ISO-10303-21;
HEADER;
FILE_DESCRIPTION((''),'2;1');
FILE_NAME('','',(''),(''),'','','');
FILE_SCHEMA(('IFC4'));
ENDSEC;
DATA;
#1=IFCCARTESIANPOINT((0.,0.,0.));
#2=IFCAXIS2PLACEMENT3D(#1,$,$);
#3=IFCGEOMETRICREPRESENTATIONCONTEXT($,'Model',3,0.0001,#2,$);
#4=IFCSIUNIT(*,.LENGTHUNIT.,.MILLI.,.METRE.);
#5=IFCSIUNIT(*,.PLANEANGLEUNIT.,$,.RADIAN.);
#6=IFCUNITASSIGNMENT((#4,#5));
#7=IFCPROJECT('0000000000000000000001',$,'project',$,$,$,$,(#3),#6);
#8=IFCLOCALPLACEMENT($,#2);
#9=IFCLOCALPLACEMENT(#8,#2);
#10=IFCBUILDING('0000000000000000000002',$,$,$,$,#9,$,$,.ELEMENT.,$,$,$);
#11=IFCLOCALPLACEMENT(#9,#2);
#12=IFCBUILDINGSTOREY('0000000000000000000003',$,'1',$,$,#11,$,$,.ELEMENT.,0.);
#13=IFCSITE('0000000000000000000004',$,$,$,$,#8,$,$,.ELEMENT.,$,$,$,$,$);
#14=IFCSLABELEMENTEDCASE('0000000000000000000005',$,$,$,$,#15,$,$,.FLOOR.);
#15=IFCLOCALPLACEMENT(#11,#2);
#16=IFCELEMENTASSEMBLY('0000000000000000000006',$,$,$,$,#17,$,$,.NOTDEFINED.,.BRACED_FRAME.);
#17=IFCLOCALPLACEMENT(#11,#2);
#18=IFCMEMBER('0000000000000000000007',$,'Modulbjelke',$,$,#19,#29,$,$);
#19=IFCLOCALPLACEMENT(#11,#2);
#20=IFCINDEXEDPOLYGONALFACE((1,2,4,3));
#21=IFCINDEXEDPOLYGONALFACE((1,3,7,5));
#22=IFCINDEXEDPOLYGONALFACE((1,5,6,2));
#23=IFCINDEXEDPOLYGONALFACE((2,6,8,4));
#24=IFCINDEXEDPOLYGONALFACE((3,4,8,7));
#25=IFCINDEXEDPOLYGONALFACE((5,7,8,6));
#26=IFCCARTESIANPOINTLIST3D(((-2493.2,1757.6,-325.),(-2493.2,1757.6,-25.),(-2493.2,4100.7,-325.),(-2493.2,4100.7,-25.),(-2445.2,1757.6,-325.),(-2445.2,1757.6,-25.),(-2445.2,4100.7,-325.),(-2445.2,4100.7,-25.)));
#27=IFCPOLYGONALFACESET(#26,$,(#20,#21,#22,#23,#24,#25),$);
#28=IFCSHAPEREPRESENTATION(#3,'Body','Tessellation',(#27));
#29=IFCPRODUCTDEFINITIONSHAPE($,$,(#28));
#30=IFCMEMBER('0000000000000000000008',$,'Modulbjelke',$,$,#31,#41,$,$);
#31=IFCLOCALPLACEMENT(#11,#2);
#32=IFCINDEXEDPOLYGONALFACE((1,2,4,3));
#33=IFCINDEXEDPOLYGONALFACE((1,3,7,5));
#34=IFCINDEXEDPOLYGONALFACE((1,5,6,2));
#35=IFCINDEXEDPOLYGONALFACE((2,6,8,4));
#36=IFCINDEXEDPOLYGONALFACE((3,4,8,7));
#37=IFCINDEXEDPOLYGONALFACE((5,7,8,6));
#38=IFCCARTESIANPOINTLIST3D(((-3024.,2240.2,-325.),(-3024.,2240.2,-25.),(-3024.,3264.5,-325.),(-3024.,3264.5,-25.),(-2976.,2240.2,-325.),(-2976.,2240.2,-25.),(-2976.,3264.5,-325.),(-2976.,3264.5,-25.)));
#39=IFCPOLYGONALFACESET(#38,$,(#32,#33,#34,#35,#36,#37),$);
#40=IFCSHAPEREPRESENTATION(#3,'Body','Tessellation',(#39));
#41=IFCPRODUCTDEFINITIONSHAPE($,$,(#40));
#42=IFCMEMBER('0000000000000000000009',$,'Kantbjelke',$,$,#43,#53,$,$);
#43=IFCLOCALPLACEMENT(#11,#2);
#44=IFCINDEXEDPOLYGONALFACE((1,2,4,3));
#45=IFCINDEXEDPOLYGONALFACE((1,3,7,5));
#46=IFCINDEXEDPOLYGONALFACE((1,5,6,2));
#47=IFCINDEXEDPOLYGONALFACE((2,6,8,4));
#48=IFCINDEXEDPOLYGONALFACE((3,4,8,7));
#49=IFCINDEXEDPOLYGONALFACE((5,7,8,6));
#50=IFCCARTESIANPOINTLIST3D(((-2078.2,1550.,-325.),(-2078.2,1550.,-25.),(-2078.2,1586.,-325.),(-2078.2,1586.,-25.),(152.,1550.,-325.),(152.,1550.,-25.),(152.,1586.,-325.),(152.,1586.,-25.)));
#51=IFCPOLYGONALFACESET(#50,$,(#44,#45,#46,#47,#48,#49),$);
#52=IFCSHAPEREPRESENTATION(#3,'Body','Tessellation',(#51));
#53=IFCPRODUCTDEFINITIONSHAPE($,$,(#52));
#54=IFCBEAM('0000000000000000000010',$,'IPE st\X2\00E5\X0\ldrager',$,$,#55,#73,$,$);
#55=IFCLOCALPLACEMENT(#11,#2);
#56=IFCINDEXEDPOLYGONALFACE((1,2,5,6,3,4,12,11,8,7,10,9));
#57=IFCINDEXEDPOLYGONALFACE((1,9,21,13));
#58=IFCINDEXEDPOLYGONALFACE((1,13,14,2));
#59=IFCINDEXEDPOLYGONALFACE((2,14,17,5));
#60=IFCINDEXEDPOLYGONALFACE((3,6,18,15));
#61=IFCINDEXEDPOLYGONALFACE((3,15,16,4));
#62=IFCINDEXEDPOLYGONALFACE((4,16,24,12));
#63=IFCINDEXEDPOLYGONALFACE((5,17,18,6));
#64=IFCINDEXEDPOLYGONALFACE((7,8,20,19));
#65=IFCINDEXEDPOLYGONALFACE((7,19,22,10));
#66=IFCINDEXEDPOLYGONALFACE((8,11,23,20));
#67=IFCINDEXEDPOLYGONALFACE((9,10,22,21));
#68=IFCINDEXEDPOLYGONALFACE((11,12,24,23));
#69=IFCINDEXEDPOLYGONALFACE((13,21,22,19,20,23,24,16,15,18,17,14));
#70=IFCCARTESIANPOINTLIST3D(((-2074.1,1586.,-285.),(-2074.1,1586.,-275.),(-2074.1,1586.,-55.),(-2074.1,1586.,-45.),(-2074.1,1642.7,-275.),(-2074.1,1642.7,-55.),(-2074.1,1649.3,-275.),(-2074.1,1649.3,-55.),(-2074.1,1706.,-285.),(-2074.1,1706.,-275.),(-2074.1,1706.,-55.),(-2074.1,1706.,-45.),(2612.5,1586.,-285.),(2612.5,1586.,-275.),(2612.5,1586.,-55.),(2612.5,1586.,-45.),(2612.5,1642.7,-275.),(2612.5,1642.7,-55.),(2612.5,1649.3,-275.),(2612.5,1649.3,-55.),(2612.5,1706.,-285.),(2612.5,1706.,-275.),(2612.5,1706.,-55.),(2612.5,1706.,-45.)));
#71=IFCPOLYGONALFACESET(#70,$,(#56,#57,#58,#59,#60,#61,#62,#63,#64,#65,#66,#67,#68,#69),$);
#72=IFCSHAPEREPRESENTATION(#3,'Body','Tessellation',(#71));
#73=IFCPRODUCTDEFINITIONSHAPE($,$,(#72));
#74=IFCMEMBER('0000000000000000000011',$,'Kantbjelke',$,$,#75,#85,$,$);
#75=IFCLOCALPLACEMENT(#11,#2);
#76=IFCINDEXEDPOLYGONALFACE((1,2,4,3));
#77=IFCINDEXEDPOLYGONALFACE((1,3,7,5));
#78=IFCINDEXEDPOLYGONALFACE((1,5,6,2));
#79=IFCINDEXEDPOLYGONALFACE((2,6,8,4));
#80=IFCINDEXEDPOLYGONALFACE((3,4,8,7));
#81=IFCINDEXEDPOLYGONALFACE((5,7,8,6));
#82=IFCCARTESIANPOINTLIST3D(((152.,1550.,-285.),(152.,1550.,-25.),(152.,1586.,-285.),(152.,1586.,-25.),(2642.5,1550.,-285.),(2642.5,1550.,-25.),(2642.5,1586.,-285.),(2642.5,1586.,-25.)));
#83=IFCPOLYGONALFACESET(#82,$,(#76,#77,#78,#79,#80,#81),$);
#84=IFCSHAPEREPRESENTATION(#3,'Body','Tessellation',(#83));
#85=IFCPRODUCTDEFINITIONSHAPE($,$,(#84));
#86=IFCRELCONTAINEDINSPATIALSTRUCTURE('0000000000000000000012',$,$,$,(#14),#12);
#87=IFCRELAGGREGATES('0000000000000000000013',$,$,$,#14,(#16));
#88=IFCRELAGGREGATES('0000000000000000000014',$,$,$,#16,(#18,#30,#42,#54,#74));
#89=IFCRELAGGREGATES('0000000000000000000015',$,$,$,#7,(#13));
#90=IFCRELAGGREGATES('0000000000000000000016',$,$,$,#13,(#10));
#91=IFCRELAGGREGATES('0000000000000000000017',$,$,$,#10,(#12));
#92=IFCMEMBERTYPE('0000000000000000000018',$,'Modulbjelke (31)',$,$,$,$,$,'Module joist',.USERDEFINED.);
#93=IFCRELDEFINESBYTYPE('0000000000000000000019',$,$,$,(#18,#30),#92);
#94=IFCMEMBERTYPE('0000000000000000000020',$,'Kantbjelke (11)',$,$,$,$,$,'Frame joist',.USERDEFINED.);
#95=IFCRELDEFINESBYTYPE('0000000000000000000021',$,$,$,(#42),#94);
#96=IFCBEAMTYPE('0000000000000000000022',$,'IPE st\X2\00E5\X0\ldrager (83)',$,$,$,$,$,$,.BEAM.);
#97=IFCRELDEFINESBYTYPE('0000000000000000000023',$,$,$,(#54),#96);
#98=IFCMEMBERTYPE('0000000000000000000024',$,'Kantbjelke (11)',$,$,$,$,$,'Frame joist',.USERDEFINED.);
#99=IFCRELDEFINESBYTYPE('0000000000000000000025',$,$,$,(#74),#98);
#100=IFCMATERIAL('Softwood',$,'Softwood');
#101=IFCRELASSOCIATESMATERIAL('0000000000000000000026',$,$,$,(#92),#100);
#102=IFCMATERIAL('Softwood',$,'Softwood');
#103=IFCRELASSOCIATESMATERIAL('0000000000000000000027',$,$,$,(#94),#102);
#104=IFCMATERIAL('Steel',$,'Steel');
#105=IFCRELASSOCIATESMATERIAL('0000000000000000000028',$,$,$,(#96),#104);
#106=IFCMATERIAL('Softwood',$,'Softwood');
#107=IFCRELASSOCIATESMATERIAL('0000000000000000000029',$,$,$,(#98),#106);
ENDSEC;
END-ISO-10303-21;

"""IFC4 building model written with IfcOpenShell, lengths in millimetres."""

from ifc_helpers import new_model, si_unit, frame, origin, place, context, project, spatial, polyline, rectangle, outline, extrude, clip, halfspace, material, material_profile, profile_set, type_object, element, aggregate, save


model = new_model("IFC4")

# Units and contexts
model_context = context("Model", 3, precision=0.0001, world=origin())
ifc_project = project(units=[si_unit("LENGTHUNIT", "METRE", prefix="MILLI"), si_unit("PLANEANGLEUNIT", "RADIAN")], contexts=[model_context])

# Site, building, storey
site_placement = place(None, origin())
site = spatial("IfcSite", under=ifc_project, at=site_placement, CompositionType="ELEMENT")
building_placement = place(site_placement, origin())
building = spatial("IfcBuilding", under=site, at=building_placement, CompositionType="ELEMENT")
storey_placement = place(building_placement, origin())
storey = spatial("IfcBuildingStorey", under=building, at=storey_placement, Name="1", CompositionType="ELEMENT", Elevation=0.0)

# Slab, element assembly
slab_placement = place(storey_placement, origin())
slab = element("IfcSlabElementedCase", 1, at=slab_placement, inside=storey, PredefinedType="FLOOR")
assembly_1_placement = place(slab_placement, frame((0.0, 0.0, -225.0)))
assembly_1 = element("IfcElementAssembly", 2, at=assembly_1_placement, AssemblyPlace="NOTDEFINED", PredefinedType="BRACED_FRAME")
aggregate(slab, [assembly_1])

# Members
ifc_material_1 = material(Name="Softwood", Category="Softwood")
ifc_material_profile_1 = material_profile(ifc_material_1, rectangle(XDim=48.0, YDim=300.0), Name="Modulbjelke (31)")
ifc_profile_set_1 = profile_set([ifc_material_profile_1])
member_type_1 = type_object("IfcMemberType", Name="Modulbjelke (31)", ElementType="Module joist", PredefinedType="USERDEFINED", material=ifc_profile_set_1)
member_1_placement = place(assembly_1_placement, frame((-2469.2, 1757.6, -100.0), z_axis=(0.0, 1.0, 0.0), x_axis=(-1.0, 0.0, 0.0)))
member_1 = element("IfcMember", 3, at=member_1_placement, type_object=member_type_1, Name="Modulbjelke", context=model_context, shape_type="SweptSolid", body=[
    extrude(rectangle(XDim=48.0, YDim=300.0), frame((0.0, 150.0, 0.0)), (0.0, 0.0, 1.0), 2343.1),
])
member_2_placement = place(assembly_1_placement, frame((-3000.0, 2240.2, -100.0), z_axis=(0.0, 1.0, 0.0), x_axis=(-1.0, 0.0, 0.0)))
member_2 = element("IfcMember", 4, at=member_2_placement, type_object=member_type_1, Name="Modulbjelke", context=model_context, shape_type="SweptSolid", body=[
    extrude(rectangle(XDim=48.0, YDim=300.0), frame((0.0, 150.0, 0.0)), (0.0, 0.0, 1.0), 1024.3),
])
ifc_material_2 = material(Name="Softwood", Category="Softwood")
ifc_material_profile_2 = material_profile(ifc_material_2, rectangle(XDim=36.0, YDim=300.0), Name="Kantbjelke (11)")
ifc_profile_set_2 = profile_set([ifc_material_profile_2])
member_type_2 = type_object("IfcMemberType", Name="Kantbjelke (11)", ElementType="Frame joist", PredefinedType="USERDEFINED", material=ifc_profile_set_2)
member_3_placement = place(assembly_1_placement, frame((-2078.2, 1568.0, -100.0), z_axis=(1.0, 0.0, 0.0), x_axis=(0.0, 1.0, 0.0)))
member_3 = element("IfcMember", 5, at=member_3_placement, type_object=member_type_2, Name="Kantbjelke", context=model_context, shape_type="SweptSolid", body=[
    extrude(rectangle(XDim=36.0, YDim=300.0), frame((0.0, 150.0, 0.0)), (0.0, 0.0, 1.0), 2230.2),
])

# Beam
ifc_material_3 = material(Name="Steel", Category="Steel")
ifc_material_profile_3 = material_profile(ifc_material_3, outline(polyline([(60.0, -120.0), (60.0, -110.0), (3.3, -110.0), (3.3, 110.0), (60.0, 110.0), (60.0, 120.0), (-60.0, 120.0), (-60.0, 110.0), (-3.3, 110.0), (-3.3, -110.0), (-60.0, -110.0), (-60.0, -120.0)])), Name="IPE ståldrager (83)")
ifc_profile_set_3 = profile_set([ifc_material_profile_3])
beam_type = type_object("IfcBeamType", Name="IPE ståldrager (83)", PredefinedType="BEAM", material=ifc_profile_set_3)
beam_placement = place(assembly_1_placement, frame((2612.5, 1646.0, -60.0), z_axis=(-1.0, 0.0, 0.0), x_axis=(0.0, -1.0, 0.0)))
beam = element("IfcBeam", 6, at=beam_placement, type_object=beam_type, Name="IPE ståldrager", context=model_context, shape_type="Clipping", body=[
    clip(clip(extrude(outline(polyline([(60.0, -120.0), (60.0, -110.0), (3.3, -110.0), (3.3, 110.0), (60.0, 110.0), (60.0, 120.0), (-60.0, 120.0), (-60.0, 110.0), (-3.3, 110.0), (-3.3, -110.0), (-60.0, -110.0), (-60.0, -120.0)])), frame((0.0, 120.0, 0.0)), (0.0, 0.0, 1.0), 4686.6), halfspace(frame((0.0, 120.0, 0.0)), True)), halfspace(frame((0.0, 120.0, 4686.6)), False)),
])

# Member
ifc_material_4 = material(Name="Softwood", Category="Softwood")
ifc_material_profile_4 = material_profile(ifc_material_4, rectangle(XDim=36.0, YDim=260.0), Name="Kantbjelke (11)")
ifc_profile_set_4 = profile_set([ifc_material_profile_4])
member_type_3 = type_object("IfcMemberType", Name="Kantbjelke (11)", ElementType="Frame joist", PredefinedType="USERDEFINED", material=ifc_profile_set_4)
member_4_placement = place(assembly_1_placement, frame((152.0, 1568.0, -60.0), z_axis=(1.0, 0.0, 0.0), x_axis=(0.0, 1.0, 0.0)))
member_4 = element("IfcMember", 7, at=member_4_placement, type_object=member_type_3, Name="Kantbjelke", context=model_context, shape_type="SweptSolid", body=[
    extrude(rectangle(XDim=36.0, YDim=260.0), frame((0.0, 130.0, 0.0)), (0.0, 0.0, 1.0), 2490.5),
])
aggregate(assembly_1, [member_1, member_2, member_3, beam, member_4])

save(model, "model.ifc")
